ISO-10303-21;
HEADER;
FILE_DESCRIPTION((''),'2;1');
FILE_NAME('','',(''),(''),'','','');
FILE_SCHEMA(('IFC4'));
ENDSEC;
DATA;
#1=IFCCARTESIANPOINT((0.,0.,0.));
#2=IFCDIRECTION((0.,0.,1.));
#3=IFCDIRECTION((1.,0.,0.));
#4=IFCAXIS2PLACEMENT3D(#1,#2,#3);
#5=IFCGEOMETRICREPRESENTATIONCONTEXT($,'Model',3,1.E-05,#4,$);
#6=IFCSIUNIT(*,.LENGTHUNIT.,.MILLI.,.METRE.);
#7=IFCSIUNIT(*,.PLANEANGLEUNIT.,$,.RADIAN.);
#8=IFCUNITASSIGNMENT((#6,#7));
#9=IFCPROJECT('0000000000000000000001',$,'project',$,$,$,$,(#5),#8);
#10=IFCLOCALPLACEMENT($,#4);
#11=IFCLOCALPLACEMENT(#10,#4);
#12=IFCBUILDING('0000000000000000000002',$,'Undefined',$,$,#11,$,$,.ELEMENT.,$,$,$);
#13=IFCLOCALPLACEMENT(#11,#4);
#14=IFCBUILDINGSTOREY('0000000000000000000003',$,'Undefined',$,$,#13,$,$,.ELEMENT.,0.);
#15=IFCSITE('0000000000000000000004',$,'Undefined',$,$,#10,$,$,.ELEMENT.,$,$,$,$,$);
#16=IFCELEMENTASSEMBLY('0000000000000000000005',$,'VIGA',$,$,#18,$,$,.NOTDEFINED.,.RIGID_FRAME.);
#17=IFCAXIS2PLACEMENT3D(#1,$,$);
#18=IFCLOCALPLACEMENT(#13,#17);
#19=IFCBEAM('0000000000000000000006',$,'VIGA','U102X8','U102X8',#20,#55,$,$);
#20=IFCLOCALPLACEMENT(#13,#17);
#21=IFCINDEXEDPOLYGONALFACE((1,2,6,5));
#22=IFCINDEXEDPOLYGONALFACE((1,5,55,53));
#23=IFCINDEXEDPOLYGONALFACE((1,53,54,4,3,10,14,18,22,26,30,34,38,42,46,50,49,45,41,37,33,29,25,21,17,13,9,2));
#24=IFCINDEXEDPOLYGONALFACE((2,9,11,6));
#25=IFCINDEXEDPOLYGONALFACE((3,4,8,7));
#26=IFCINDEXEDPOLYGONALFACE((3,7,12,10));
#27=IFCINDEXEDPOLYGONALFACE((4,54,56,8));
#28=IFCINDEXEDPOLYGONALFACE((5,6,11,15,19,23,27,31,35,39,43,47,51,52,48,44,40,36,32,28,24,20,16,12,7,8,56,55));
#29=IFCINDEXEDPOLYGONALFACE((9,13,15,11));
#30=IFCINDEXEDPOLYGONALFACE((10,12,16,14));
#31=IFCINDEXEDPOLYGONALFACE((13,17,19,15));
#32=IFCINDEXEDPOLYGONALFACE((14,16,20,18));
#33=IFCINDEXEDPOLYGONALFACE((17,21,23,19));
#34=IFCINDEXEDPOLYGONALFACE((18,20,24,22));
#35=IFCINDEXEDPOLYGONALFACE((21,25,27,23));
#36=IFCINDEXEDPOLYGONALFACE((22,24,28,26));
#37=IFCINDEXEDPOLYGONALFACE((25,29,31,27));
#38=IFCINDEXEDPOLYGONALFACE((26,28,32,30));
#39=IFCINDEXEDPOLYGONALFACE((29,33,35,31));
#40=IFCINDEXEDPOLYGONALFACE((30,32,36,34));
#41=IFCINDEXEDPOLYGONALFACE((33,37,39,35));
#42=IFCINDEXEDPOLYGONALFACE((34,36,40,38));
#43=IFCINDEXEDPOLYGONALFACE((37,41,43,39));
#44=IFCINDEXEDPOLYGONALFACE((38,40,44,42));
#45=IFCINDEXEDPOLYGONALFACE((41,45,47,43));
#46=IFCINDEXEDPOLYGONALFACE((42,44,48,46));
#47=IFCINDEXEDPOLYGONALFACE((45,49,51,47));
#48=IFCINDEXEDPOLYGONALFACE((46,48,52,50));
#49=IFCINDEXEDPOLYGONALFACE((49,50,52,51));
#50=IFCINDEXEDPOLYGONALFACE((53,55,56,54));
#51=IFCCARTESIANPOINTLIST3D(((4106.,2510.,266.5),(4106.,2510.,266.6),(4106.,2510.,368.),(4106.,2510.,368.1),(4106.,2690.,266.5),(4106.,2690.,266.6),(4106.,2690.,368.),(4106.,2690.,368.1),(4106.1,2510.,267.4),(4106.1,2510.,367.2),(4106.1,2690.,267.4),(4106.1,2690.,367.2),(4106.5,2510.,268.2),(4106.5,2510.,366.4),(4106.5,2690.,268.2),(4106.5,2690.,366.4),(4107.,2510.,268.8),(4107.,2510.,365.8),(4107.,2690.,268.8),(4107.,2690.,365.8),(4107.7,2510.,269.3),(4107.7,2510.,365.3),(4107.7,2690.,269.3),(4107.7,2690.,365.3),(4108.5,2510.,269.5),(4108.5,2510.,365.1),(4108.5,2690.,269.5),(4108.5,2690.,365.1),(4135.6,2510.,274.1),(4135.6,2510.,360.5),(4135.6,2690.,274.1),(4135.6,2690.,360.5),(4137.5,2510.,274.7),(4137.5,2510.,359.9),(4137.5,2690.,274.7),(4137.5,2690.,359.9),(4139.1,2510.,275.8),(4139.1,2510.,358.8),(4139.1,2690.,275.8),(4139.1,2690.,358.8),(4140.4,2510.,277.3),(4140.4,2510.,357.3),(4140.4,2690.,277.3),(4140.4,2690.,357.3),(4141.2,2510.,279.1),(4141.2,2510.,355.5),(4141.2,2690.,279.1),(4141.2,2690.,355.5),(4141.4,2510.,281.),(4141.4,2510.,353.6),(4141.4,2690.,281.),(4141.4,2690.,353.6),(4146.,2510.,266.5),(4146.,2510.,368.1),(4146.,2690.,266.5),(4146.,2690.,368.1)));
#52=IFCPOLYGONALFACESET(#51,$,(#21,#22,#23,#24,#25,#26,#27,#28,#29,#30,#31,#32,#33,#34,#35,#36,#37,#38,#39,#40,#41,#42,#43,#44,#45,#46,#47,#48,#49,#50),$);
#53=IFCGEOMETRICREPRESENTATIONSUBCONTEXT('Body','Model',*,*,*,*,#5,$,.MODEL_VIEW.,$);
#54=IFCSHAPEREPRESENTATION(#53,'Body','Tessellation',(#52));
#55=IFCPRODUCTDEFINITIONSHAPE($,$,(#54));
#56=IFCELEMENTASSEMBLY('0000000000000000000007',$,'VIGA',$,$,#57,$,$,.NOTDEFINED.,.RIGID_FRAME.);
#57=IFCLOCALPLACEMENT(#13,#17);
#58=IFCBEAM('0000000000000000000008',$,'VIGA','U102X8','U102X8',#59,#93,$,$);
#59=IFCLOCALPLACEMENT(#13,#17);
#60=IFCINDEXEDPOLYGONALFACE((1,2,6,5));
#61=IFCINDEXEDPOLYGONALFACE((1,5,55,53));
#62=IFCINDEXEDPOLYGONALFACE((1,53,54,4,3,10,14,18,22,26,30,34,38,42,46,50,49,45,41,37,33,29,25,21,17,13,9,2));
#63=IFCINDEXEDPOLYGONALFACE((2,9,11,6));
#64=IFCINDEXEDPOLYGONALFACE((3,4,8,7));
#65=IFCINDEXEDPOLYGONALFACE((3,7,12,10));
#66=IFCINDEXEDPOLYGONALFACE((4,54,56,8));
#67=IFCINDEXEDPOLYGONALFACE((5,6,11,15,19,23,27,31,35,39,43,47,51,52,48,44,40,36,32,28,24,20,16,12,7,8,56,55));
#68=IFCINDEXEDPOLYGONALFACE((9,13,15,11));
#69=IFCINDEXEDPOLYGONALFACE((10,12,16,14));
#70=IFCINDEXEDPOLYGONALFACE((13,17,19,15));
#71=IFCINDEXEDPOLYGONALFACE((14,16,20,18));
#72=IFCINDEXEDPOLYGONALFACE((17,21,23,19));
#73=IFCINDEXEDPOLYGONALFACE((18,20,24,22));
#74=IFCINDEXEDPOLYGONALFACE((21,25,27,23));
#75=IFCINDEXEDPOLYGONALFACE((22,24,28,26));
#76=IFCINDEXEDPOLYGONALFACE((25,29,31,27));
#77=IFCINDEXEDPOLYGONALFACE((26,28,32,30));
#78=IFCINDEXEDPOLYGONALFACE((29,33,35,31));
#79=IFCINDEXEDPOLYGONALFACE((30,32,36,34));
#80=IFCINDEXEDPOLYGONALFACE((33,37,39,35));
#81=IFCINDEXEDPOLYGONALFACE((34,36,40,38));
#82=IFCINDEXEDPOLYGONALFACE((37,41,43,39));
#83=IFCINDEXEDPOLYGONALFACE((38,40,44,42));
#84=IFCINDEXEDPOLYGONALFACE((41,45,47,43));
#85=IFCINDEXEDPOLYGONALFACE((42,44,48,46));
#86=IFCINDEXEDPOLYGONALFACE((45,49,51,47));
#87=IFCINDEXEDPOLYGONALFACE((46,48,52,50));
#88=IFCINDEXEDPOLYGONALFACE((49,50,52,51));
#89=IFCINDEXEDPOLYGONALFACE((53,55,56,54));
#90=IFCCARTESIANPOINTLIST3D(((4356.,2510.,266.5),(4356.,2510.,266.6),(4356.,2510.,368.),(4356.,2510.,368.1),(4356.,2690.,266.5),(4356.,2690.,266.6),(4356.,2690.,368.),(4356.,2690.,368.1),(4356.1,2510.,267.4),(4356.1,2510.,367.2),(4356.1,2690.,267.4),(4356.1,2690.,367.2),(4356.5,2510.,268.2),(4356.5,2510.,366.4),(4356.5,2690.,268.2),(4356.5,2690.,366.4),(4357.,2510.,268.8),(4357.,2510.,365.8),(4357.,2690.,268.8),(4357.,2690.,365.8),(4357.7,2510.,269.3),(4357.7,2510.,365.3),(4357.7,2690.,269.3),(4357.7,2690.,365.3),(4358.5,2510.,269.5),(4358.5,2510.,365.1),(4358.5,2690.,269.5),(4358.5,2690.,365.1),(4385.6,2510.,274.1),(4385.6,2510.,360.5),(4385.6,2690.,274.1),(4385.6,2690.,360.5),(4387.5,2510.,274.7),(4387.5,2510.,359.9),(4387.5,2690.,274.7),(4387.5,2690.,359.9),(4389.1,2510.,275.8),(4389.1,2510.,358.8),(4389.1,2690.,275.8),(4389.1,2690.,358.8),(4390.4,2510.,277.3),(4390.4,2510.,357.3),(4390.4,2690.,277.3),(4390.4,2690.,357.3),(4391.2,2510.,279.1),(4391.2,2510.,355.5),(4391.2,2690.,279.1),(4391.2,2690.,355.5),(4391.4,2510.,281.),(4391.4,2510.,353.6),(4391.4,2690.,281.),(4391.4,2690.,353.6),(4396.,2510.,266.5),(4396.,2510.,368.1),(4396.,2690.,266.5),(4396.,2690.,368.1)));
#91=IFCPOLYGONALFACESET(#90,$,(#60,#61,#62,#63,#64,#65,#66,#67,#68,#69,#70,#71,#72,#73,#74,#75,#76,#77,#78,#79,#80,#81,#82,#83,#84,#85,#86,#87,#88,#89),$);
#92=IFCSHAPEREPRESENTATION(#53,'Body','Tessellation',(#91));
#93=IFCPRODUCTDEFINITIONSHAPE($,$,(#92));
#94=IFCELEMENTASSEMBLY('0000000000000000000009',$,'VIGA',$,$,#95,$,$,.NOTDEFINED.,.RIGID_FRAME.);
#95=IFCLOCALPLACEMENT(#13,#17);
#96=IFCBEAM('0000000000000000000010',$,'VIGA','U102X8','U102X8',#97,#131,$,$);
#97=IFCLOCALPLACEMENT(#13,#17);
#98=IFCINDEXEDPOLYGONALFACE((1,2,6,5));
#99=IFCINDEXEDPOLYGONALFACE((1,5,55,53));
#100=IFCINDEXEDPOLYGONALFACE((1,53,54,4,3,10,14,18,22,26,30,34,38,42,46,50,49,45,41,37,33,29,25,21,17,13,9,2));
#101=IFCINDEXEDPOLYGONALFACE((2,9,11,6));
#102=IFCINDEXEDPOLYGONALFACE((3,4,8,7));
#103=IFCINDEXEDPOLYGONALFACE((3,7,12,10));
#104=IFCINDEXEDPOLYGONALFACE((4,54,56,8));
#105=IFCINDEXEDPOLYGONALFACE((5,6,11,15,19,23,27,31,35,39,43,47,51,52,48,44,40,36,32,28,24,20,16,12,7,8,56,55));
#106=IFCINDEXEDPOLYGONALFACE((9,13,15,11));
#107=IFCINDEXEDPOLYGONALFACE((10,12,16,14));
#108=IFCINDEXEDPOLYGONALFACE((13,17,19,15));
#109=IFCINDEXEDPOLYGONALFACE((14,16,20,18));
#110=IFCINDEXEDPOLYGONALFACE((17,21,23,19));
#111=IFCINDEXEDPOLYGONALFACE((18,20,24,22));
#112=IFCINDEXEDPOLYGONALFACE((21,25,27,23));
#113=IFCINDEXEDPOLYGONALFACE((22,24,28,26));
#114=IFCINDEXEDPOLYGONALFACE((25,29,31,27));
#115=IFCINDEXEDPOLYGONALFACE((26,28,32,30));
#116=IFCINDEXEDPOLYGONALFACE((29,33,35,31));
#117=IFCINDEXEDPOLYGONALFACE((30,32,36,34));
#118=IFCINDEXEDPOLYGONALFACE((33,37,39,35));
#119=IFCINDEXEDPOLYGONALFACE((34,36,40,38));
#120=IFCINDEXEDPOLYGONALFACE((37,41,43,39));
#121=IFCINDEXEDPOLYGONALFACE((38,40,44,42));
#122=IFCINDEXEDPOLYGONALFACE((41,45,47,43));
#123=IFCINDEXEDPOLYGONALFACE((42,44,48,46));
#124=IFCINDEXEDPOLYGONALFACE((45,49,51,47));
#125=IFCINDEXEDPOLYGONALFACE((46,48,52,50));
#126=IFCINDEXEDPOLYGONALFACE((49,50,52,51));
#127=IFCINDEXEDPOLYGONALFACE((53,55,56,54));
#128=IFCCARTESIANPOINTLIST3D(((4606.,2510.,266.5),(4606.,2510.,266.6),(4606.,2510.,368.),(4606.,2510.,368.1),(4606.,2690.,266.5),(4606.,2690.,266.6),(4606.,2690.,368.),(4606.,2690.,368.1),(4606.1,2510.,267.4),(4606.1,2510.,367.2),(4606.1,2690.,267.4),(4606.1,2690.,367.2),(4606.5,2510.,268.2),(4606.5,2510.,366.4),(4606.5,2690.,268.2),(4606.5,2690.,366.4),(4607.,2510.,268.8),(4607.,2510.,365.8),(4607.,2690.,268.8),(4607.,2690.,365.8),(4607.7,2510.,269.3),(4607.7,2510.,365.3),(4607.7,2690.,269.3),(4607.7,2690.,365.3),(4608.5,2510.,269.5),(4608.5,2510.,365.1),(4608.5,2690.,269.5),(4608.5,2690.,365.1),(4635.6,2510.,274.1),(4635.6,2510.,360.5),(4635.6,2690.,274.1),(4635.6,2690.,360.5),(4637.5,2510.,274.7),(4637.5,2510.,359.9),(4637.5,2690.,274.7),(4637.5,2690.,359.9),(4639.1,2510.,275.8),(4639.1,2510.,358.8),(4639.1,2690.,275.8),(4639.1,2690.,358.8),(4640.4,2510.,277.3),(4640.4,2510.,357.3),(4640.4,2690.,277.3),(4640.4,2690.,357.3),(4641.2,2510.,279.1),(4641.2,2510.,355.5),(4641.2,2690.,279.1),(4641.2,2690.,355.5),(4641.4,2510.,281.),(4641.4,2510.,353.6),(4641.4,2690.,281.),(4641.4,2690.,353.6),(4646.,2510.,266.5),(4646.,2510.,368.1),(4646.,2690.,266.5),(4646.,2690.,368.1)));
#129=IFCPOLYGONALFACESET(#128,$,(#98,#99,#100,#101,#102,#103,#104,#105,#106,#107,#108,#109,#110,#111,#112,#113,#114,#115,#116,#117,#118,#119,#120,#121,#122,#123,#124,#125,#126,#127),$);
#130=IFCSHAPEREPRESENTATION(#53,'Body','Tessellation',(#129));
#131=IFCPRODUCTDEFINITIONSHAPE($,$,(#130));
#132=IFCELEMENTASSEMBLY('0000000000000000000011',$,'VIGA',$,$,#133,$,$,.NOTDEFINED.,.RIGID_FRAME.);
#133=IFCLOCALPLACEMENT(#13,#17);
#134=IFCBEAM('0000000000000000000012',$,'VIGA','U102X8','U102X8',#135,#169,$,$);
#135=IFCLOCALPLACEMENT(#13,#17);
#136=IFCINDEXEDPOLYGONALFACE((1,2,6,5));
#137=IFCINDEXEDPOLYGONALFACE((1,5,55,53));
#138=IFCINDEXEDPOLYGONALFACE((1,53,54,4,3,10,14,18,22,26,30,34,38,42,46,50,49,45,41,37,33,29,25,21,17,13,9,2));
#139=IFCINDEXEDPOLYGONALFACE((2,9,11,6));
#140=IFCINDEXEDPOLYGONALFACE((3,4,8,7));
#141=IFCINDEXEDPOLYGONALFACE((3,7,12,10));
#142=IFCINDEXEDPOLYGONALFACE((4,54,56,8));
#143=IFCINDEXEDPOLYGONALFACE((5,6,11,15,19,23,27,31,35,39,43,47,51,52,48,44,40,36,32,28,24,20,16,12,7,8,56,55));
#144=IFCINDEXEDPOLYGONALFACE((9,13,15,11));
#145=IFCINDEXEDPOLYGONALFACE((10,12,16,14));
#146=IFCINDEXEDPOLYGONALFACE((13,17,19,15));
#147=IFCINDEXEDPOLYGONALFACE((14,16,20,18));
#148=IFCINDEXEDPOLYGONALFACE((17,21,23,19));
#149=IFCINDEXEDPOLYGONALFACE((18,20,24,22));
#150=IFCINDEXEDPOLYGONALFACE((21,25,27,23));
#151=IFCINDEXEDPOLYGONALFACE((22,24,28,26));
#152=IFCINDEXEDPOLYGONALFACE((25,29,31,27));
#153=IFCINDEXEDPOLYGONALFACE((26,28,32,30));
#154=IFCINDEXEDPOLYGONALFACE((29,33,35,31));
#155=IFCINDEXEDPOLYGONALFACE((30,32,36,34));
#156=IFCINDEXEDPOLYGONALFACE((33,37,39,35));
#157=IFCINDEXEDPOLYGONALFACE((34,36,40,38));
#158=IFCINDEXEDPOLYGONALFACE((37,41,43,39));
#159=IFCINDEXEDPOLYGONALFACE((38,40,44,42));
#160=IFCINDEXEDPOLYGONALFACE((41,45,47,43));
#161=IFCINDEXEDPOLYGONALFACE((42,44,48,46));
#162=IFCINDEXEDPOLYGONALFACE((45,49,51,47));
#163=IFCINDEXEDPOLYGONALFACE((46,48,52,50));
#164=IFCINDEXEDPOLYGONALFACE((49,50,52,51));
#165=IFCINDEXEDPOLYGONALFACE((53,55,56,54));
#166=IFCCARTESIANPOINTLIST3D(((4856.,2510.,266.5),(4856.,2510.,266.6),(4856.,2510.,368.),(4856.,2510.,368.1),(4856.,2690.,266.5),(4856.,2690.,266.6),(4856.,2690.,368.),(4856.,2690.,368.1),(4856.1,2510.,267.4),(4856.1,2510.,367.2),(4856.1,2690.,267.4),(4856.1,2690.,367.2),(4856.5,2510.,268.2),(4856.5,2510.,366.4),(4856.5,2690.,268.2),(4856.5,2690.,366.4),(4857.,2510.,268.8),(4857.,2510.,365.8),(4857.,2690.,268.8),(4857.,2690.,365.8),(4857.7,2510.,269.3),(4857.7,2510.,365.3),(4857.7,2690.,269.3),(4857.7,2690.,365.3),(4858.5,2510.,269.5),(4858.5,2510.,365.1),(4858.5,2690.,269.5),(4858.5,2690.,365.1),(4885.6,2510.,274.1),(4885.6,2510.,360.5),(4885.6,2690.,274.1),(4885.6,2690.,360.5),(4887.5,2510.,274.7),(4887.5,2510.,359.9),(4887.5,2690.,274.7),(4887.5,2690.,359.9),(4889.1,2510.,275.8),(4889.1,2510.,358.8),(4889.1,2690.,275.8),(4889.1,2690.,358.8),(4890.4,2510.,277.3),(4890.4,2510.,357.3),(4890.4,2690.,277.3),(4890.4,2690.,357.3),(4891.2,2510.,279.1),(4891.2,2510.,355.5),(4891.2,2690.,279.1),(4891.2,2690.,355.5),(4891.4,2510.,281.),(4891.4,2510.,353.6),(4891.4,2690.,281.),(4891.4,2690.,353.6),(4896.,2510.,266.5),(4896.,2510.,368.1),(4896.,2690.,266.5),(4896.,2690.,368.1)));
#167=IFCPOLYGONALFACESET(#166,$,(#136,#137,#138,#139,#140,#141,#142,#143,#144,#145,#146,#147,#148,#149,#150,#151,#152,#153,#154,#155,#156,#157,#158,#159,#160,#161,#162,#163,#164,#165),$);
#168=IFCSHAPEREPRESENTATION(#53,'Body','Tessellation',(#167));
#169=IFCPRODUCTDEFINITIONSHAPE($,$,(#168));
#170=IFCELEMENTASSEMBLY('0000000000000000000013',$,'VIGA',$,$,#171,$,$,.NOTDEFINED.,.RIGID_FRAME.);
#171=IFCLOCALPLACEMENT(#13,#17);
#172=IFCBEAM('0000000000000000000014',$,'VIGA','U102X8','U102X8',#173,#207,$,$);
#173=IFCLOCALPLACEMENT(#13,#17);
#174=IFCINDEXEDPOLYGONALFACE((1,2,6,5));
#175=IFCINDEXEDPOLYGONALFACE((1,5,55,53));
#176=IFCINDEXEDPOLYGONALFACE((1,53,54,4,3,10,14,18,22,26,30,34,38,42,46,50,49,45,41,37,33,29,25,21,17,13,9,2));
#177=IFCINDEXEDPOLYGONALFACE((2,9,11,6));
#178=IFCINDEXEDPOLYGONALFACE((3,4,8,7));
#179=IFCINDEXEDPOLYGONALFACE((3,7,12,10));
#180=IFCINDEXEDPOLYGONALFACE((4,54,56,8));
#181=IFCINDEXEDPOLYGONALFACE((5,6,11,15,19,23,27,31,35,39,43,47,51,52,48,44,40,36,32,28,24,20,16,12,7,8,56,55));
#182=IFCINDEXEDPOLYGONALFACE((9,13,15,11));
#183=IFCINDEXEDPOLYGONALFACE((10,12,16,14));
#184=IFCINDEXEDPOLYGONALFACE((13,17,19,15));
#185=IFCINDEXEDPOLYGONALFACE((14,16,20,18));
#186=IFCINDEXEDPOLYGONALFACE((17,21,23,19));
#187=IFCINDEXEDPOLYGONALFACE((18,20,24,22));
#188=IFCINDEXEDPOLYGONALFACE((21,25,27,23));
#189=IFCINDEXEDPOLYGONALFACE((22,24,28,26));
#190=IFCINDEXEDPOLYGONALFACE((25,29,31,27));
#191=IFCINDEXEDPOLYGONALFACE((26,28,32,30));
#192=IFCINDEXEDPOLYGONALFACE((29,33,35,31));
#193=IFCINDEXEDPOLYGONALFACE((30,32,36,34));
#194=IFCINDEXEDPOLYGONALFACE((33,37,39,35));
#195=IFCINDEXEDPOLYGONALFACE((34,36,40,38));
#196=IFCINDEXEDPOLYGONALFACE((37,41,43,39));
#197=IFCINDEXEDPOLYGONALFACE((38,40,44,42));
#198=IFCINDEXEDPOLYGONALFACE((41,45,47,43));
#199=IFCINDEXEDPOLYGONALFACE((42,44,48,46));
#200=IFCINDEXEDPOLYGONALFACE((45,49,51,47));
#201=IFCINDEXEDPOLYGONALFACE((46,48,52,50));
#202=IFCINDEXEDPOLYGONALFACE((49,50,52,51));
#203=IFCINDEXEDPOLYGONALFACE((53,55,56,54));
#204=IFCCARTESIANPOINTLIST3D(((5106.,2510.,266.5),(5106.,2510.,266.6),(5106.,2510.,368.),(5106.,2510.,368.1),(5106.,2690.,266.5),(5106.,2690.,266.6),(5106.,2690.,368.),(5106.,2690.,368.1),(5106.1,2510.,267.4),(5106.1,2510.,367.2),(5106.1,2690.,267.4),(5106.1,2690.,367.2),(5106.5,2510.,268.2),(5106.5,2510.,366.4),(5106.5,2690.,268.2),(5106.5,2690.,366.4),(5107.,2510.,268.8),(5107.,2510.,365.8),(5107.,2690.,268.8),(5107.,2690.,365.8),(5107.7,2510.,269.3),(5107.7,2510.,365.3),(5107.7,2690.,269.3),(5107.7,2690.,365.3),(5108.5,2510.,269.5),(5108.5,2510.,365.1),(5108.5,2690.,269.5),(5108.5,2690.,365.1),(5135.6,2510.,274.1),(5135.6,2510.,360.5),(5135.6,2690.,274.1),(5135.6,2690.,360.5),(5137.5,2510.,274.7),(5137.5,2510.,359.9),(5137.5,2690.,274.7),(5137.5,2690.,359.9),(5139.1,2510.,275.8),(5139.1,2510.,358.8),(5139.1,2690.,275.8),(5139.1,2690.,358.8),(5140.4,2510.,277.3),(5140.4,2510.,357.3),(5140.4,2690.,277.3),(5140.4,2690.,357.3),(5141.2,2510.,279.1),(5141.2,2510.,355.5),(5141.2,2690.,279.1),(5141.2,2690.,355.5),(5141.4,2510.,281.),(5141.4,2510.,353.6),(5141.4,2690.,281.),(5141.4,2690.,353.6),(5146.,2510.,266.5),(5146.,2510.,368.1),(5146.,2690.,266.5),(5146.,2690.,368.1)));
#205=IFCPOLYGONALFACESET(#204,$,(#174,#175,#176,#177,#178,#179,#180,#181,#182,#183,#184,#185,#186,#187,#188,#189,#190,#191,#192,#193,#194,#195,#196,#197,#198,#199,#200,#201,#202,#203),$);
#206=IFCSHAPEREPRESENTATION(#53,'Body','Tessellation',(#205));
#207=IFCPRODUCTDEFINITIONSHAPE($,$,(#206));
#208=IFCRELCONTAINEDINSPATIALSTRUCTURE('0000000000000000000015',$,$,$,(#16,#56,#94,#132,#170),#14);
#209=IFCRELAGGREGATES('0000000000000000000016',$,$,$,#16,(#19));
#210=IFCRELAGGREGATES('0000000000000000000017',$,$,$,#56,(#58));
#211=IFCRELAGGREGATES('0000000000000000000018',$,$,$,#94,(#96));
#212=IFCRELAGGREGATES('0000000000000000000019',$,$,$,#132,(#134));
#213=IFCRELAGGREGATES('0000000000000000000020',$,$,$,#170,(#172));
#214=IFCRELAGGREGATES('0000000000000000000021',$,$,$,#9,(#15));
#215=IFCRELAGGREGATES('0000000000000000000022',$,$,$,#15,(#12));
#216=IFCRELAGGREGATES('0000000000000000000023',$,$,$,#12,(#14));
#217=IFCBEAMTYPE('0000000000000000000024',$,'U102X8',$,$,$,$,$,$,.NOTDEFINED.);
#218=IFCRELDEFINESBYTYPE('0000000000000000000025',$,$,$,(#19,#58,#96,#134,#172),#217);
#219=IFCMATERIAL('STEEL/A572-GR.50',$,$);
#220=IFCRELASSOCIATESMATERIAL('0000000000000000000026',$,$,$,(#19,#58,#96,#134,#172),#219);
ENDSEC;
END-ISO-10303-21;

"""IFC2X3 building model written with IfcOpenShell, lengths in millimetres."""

from ifc_helpers import new_model, si_unit, frame, origin_with_axes, origin_2d_with_axis, place, context, subcontext, project, spatial, u_section, extrude, material, type_object, element, aggregate, save


model = new_model("IFC2X3")

# Units and contexts
model_context = context("Model", 3, precision=1e-05, world=origin_with_axes())
body_context = subcontext(model_context, "Body", "Model", "MODEL_VIEW")
ifc_project = project(units=[si_unit("LENGTHUNIT", "METRE", prefix="MILLI"), si_unit("PLANEANGLEUNIT", "RADIAN")], contexts=[model_context])

# Site, building, storey
site_placement = place(None, origin_with_axes())
site = spatial("IfcSite", under=ifc_project, at=site_placement, Name="Undefined", CompositionType="ELEMENT")
building_placement = place(site_placement, origin_with_axes())
building = spatial("IfcBuilding", under=site, at=building_placement, Name="Undefined", CompositionType="ELEMENT")
storey_placement = place(building_placement, origin_with_axes())
storey = spatial("IfcBuildingStorey", under=building, at=storey_placement, Name="Undefined", CompositionType="ELEMENT", Elevation=0.0)

# Element assemblies, beams
ifc_material_1 = material(Name="STEEL/A572-GR.50")
beam_type = type_object("IfcBeamType", Name="U102X8", PredefinedType="NOTDEFINED")
assembly_1_placement = place(storey_placement, origin_with_axes())
assembly_1 = element("IfcElementAssembly", 1, at=assembly_1_placement, inside=storey, Name="VIGA", AssemblyPlace="NOTDEFINED", PredefinedType="RIGID_FRAME")
beam_1_placement = place(assembly_1_placement, frame((4126.0, 2690.0, 317.3), z_axis=(0.0, 0.0, 1.0), x_axis=(0.0, -1.0, 0.0)))
beam_1 = element("IfcBeam", 2, at=beam_1_placement, type_object=beam_type, material=ifc_material_1, Name="VIGA", Description="U102X8", ObjectType="U102X8", context=body_context, shape_type="SweptSolid", body=[
    extrude(u_section(Depth=101.6, FlangeWidth=40.0, WebThickness=4.6, FlangeThickness=6.0, FilletRadius=7.0, EdgeRadius=3.0, FlangeSlope=0.16839, at=origin_2d_with_axis()), frame((180.0, 0.0, 0.0), z_axis=(-1.0, 0.0, 0.0), x_axis=(0.0, -1.0, 0.0)), (0.0, 0.0, 1.0), 180.0),
])
aggregate(assembly_1, [beam_1])
assembly_2_placement = place(storey_placement, origin_with_axes())
assembly_2 = element("IfcElementAssembly", 3, at=assembly_2_placement, inside=storey, Name="VIGA", AssemblyPlace="NOTDEFINED", PredefinedType="RIGID_FRAME")
beam_2_placement = place(assembly_2_placement, frame((4376.0, 2690.0, 317.3), z_axis=(0.0, 0.0, 1.0), x_axis=(0.0, -1.0, 0.0)))
beam_2 = element("IfcBeam", 4, at=beam_2_placement, type_object=beam_type, material=ifc_material_1, Name="VIGA", Description="U102X8", ObjectType="U102X8", context=body_context, shape_type="SweptSolid", body=[
    extrude(u_section(Depth=101.6, FlangeWidth=40.0, WebThickness=4.6, FlangeThickness=6.0, FilletRadius=7.0, EdgeRadius=3.0, FlangeSlope=0.16839, at=origin_2d_with_axis()), frame((180.0, 0.0, 0.0), z_axis=(-1.0, 0.0, 0.0), x_axis=(0.0, -1.0, 0.0)), (0.0, 0.0, 1.0), 180.0),
])
aggregate(assembly_2, [beam_2])
assembly_3_placement = place(storey_placement, origin_with_axes())
assembly_3 = element("IfcElementAssembly", 5, at=assembly_3_placement, inside=storey, Name="VIGA", AssemblyPlace="NOTDEFINED", PredefinedType="RIGID_FRAME")
beam_3_placement = place(assembly_3_placement, frame((4626.0, 2690.0, 317.3), z_axis=(0.0, 0.0, 1.0), x_axis=(0.0, -1.0, 0.0)))
beam_3 = element("IfcBeam", 6, at=beam_3_placement, type_object=beam_type, material=ifc_material_1, Name="VIGA", Description="U102X8", ObjectType="U102X8", context=body_context, shape_type="SweptSolid", body=[
    extrude(u_section(Depth=101.6, FlangeWidth=40.0, WebThickness=4.6, FlangeThickness=6.0, FilletRadius=7.0, EdgeRadius=3.0, FlangeSlope=0.16839, at=origin_2d_with_axis()), frame((180.0, 0.0, 0.0), z_axis=(-1.0, 0.0, 0.0), x_axis=(0.0, -1.0, 0.0)), (0.0, 0.0, 1.0), 180.0),
])
aggregate(assembly_3, [beam_3])
assembly_4_placement = place(storey_placement, origin_with_axes())
assembly_4 = element("IfcElementAssembly", 7, at=assembly_4_placement, inside=storey, Name="VIGA", AssemblyPlace="NOTDEFINED", PredefinedType="RIGID_FRAME")
beam_4_placement = place(assembly_4_placement, frame((4876.0, 2690.0, 317.3), z_axis=(0.0, 0.0, 1.0), x_axis=(0.0, -1.0, 0.0)))
beam_4 = element("IfcBeam", 8, at=beam_4_placement, type_object=beam_type, material=ifc_material_1, Name="VIGA", Description="U102X8", ObjectType="U102X8", context=body_context, shape_type="SweptSolid", body=[
    extrude(u_section(Depth=101.6, FlangeWidth=40.0, WebThickness=4.6, FlangeThickness=6.0, FilletRadius=7.0, EdgeRadius=3.0, FlangeSlope=0.16839, at=origin_2d_with_axis()), frame((180.0, 0.0, 0.0), z_axis=(-1.0, 0.0, 0.0), x_axis=(0.0, -1.0, 0.0)), (0.0, 0.0, 1.0), 180.0),
])
aggregate(assembly_4, [beam_4])
assembly_5_placement = place(storey_placement, origin_with_axes())
assembly_5 = element("IfcElementAssembly", 9, at=assembly_5_placement, inside=storey, Name="VIGA", AssemblyPlace="NOTDEFINED", PredefinedType="RIGID_FRAME")
beam_5_placement = place(assembly_5_placement, frame((5126.0, 2690.0, 317.3), z_axis=(0.0, 0.0, 1.0), x_axis=(0.0, -1.0, 0.0)))
beam_5 = element("IfcBeam", 10, at=beam_5_placement, type_object=beam_type, material=ifc_material_1, Name="VIGA", Description="U102X8", ObjectType="U102X8", context=body_context, shape_type="SweptSolid", body=[
    extrude(u_section(Depth=101.6, FlangeWidth=40.0, WebThickness=4.6, FlangeThickness=6.0, FilletRadius=7.0, EdgeRadius=3.0, FlangeSlope=0.16839, at=origin_2d_with_axis()), frame((180.0, 0.0, 0.0), z_axis=(-1.0, 0.0, 0.0), x_axis=(0.0, -1.0, 0.0)), (0.0, 0.0, 1.0), 180.0),
])
aggregate(assembly_5, [beam_5])

save(model, "model.ifc")
